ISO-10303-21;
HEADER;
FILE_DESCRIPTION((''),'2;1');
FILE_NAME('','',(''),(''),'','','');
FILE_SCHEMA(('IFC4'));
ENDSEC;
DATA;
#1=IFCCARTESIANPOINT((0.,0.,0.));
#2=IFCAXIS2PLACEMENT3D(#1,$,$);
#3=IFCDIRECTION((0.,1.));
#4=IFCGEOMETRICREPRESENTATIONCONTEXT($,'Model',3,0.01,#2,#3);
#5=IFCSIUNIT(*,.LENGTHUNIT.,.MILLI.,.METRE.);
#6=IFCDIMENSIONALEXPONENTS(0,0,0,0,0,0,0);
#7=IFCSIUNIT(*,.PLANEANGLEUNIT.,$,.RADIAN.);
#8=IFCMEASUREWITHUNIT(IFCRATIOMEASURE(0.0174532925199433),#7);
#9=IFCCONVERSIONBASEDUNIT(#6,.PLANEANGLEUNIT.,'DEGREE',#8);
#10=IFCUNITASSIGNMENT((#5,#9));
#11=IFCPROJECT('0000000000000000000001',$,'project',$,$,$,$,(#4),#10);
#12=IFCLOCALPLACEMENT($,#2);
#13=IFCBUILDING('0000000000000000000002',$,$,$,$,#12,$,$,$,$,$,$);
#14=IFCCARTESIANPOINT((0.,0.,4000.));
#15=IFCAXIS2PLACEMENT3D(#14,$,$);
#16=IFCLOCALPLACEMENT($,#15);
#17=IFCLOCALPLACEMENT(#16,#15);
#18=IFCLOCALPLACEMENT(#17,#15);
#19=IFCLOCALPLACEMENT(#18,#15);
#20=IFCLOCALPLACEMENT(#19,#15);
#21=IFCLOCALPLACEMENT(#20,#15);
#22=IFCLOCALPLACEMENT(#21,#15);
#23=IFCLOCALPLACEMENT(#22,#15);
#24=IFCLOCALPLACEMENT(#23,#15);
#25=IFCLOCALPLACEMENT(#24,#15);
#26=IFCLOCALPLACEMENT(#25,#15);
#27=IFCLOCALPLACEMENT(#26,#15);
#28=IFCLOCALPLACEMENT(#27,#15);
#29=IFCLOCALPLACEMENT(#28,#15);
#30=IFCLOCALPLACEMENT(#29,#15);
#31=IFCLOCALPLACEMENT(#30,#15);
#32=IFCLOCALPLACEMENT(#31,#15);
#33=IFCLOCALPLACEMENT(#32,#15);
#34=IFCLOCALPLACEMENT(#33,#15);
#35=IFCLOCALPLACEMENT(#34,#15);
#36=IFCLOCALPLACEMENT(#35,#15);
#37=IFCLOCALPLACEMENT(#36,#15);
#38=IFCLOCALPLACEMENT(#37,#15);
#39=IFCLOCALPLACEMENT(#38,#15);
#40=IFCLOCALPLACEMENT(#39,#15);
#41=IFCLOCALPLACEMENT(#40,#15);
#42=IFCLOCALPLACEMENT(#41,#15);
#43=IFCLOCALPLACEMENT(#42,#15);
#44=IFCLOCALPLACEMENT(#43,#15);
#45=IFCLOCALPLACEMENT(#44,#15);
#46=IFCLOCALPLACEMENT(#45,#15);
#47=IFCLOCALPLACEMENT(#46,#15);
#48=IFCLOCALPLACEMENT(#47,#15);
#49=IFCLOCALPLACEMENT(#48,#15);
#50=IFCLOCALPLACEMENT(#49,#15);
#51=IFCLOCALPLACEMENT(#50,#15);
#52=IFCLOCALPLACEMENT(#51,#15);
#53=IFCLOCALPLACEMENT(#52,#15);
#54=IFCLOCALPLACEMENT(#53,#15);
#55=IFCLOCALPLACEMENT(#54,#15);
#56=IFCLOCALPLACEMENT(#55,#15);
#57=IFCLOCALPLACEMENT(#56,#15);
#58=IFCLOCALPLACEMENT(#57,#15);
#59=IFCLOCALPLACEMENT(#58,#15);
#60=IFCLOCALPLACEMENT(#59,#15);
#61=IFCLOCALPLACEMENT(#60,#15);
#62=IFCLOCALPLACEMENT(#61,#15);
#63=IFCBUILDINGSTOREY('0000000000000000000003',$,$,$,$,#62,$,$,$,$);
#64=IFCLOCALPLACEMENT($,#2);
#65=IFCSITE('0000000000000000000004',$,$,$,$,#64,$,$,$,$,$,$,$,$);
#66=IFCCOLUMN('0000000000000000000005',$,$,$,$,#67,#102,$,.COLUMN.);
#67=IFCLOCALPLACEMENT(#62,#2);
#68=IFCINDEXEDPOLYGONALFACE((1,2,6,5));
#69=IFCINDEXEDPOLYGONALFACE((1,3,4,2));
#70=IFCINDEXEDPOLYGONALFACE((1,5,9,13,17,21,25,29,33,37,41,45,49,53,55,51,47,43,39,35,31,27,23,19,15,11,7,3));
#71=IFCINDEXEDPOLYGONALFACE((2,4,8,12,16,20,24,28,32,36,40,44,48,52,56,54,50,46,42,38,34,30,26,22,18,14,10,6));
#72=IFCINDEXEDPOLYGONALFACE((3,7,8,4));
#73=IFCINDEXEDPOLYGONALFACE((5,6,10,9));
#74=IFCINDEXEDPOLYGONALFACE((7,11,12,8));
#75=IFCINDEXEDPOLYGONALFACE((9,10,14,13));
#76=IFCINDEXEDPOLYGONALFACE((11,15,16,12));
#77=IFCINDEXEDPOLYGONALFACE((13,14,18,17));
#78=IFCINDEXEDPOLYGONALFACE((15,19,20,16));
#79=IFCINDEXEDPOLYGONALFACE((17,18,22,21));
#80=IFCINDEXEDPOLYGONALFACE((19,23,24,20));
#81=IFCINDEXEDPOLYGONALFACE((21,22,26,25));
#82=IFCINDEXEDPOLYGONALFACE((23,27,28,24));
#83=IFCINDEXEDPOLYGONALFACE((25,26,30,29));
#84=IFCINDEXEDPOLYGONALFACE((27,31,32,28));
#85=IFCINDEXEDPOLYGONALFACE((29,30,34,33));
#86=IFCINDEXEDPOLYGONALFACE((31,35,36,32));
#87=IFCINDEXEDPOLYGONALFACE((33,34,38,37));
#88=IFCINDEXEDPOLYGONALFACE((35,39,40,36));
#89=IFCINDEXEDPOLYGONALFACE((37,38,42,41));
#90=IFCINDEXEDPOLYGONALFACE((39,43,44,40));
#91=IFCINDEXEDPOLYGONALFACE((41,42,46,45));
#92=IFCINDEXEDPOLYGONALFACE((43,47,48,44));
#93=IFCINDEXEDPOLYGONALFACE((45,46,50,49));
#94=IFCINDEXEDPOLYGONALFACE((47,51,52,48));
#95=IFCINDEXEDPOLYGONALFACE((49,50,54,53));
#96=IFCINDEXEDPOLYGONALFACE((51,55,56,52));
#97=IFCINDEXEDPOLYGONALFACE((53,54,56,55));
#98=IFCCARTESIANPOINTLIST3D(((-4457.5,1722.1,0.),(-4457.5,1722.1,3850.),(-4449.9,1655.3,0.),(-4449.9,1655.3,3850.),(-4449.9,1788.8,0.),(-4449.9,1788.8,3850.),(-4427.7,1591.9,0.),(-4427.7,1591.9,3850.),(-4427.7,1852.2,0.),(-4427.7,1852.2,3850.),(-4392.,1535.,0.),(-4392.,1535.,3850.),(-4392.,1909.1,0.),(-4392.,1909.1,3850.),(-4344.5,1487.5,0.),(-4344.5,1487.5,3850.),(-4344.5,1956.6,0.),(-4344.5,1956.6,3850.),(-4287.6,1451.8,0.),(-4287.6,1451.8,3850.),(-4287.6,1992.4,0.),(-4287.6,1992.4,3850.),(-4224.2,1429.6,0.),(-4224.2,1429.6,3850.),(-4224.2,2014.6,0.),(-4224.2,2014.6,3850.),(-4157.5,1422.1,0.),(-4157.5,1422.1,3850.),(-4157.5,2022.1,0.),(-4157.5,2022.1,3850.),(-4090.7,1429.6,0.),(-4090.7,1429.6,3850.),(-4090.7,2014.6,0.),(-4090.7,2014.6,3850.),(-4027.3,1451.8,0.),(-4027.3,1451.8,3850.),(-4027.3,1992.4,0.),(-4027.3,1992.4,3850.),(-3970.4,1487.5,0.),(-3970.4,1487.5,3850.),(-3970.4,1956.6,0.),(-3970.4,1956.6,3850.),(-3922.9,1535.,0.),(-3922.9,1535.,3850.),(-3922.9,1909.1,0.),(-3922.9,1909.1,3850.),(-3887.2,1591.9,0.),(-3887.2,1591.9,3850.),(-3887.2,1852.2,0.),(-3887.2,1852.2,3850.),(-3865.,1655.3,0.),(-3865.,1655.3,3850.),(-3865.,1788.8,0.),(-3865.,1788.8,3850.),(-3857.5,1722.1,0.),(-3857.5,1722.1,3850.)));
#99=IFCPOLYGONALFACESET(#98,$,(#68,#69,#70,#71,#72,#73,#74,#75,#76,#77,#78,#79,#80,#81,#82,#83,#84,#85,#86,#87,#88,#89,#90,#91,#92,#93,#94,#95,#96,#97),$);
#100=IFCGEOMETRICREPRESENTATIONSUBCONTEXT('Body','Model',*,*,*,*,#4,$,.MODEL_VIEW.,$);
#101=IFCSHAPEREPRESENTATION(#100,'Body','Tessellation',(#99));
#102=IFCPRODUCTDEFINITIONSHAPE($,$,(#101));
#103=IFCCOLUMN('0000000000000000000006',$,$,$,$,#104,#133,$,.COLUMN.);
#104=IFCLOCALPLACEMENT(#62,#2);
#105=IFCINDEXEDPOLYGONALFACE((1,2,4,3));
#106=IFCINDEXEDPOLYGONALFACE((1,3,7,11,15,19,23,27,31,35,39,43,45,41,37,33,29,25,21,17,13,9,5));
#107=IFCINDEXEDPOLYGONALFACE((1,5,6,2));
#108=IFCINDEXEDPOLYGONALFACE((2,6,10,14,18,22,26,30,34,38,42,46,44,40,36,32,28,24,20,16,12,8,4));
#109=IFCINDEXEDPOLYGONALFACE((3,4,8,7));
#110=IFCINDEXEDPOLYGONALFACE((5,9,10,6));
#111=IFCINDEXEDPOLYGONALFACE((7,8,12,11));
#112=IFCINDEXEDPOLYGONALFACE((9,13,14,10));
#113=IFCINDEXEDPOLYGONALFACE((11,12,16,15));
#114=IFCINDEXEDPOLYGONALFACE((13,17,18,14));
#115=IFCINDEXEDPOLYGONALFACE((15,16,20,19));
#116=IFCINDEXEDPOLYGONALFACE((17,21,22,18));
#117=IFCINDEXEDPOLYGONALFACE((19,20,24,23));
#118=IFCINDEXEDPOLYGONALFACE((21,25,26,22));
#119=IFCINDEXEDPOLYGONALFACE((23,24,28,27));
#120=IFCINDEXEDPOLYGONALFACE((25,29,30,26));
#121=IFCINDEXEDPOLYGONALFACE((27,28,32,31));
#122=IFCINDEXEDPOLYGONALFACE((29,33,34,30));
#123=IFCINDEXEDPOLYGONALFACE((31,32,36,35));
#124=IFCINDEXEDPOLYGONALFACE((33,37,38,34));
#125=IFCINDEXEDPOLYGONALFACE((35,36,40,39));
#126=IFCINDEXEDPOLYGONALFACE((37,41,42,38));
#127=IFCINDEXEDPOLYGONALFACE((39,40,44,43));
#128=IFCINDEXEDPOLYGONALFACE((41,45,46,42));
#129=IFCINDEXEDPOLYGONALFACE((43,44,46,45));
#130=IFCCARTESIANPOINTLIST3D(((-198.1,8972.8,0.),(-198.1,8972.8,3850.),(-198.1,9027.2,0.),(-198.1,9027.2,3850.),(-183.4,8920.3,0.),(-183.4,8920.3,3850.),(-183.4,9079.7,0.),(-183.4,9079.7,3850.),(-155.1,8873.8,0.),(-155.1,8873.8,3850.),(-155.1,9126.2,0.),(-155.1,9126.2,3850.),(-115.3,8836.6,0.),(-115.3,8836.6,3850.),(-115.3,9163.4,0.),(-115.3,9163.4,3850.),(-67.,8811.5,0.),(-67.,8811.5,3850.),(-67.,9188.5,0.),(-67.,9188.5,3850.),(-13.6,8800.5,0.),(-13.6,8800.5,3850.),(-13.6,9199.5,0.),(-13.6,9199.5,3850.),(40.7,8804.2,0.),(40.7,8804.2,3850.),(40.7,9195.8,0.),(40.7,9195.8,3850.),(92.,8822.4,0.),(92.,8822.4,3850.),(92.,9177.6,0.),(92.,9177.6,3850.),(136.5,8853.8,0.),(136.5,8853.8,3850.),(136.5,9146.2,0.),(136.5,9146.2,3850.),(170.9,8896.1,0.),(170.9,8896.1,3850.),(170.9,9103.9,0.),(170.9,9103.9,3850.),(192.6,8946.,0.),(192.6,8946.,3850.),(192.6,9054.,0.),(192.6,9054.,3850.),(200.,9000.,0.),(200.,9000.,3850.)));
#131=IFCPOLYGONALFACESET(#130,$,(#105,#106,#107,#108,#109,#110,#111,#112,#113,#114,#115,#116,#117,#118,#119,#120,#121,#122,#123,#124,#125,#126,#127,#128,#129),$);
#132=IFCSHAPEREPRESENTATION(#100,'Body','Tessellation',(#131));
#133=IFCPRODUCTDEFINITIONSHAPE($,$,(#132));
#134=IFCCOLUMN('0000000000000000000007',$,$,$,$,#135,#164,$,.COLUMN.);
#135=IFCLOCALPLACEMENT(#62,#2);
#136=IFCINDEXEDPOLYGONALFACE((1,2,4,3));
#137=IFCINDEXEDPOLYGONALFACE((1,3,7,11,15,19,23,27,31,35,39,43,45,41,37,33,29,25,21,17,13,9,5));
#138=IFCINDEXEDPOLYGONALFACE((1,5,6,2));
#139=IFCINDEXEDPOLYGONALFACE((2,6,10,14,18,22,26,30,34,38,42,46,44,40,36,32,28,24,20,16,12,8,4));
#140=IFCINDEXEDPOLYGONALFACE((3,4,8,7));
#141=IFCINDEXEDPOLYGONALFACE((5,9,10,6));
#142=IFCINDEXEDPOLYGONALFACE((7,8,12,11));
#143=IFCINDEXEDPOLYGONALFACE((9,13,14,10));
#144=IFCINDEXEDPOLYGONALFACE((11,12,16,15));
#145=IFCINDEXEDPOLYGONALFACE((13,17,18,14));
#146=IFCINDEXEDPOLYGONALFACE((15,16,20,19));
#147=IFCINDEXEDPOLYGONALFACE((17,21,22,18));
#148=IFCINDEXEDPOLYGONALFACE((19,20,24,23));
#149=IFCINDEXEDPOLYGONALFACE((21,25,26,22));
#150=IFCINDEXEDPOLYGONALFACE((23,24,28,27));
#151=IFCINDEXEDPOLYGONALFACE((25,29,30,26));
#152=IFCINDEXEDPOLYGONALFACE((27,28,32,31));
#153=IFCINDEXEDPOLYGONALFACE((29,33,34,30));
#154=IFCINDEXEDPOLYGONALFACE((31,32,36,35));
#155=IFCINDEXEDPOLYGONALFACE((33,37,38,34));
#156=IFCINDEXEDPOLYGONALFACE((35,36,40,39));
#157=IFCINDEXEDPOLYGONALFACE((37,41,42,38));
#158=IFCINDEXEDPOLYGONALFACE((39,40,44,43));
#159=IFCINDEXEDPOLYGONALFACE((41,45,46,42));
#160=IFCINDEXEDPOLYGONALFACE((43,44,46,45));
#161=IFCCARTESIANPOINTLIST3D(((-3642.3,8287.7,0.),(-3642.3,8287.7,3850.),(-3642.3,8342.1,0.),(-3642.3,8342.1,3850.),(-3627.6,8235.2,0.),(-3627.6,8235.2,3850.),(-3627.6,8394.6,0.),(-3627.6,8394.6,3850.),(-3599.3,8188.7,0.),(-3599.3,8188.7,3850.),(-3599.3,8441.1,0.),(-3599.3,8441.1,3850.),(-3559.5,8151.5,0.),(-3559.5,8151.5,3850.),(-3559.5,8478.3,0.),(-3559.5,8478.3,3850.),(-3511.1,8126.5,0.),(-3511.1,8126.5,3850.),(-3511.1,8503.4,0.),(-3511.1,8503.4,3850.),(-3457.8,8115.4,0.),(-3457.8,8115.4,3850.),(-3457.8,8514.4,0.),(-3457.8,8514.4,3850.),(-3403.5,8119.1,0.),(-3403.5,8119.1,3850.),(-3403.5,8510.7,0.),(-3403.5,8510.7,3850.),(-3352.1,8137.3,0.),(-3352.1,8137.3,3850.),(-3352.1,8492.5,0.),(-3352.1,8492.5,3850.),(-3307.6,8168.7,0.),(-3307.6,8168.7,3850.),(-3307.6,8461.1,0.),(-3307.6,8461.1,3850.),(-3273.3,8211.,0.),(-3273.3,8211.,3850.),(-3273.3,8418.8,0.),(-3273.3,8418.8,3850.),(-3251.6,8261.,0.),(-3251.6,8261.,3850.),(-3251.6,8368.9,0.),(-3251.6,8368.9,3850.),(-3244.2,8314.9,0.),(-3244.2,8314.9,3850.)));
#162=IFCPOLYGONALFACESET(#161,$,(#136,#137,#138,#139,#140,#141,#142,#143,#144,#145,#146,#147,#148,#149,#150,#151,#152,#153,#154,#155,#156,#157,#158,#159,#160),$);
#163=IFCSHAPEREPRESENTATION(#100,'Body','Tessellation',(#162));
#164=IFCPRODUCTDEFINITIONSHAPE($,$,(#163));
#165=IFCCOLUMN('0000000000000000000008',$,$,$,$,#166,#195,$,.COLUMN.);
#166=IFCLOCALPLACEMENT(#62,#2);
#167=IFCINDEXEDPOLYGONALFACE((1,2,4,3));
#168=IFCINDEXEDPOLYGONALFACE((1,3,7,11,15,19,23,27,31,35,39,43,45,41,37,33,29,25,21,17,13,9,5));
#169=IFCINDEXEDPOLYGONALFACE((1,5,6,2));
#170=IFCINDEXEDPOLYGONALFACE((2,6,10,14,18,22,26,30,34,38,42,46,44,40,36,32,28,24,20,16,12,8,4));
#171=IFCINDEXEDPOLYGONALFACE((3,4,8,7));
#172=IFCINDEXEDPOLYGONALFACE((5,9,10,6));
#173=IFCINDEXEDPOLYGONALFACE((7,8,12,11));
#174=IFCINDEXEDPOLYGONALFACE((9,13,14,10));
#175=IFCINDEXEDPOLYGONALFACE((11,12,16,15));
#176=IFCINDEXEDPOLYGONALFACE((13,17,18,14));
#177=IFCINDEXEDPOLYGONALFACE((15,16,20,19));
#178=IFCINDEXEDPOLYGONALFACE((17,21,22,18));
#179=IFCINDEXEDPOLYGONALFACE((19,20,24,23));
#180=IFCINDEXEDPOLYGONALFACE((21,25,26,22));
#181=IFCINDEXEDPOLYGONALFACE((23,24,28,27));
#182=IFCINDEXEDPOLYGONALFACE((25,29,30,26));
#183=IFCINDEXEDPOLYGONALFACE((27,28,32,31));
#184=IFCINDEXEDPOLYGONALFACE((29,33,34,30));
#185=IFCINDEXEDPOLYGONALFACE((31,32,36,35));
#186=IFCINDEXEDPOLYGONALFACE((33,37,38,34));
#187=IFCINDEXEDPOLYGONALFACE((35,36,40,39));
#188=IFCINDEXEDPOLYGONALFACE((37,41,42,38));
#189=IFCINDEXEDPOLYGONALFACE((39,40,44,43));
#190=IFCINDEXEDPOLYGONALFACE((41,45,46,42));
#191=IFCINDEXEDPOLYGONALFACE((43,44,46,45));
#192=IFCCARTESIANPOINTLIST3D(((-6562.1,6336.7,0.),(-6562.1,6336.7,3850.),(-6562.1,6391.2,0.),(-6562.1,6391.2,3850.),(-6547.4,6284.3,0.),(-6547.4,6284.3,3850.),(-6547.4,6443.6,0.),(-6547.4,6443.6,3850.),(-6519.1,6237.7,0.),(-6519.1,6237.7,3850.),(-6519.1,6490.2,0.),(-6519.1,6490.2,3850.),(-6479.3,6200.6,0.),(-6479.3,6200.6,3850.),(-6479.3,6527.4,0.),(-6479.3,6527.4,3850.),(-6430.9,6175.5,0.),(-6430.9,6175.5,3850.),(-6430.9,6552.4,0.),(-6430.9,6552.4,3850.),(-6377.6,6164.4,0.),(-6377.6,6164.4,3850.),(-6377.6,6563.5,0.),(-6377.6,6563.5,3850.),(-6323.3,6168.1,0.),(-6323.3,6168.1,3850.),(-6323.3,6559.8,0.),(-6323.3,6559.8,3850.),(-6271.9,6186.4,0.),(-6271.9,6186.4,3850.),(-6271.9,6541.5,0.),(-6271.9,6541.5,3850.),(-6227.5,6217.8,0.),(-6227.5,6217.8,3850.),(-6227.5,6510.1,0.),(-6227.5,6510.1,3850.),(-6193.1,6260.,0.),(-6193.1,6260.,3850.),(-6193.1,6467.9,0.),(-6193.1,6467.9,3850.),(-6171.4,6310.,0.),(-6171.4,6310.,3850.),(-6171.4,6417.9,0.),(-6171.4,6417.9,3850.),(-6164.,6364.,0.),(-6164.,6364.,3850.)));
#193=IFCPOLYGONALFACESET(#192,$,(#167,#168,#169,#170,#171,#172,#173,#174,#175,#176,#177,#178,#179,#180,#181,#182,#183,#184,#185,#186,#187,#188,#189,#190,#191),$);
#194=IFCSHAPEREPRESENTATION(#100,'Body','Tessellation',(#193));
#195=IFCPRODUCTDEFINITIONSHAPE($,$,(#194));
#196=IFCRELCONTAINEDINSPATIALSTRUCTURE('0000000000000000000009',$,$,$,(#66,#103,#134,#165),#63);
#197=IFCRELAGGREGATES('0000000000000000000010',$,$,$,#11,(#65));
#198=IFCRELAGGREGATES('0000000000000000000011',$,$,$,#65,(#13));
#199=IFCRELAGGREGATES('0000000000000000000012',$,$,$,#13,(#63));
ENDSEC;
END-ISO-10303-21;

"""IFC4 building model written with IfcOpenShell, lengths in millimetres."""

from ifc_helpers import new_model, entity, si_unit, converted_unit, direction, frame, origin, origin_2d, place, context, subcontext, project, spatial, circle, extrude, element, save


model = new_model("IFC4")

# Units and contexts
model_context = context("Model", 3, precision=0.01, world=origin(), true_north=direction((0.0, 1.0)))
body_context = subcontext(model_context, "Body", "Model", "MODEL_VIEW")
ifc_project = project(units=[si_unit("LENGTHUNIT", "METRE", prefix="MILLI"), converted_unit("PLANEANGLEUNIT", "DEGREE", entity("IfcRatioMeasure", 0.0174532925199433), si_unit("PLANEANGLEUNIT", "RADIAN"), dimensions=[0, 0, 0, 0, 0, 0, 0])], contexts=[model_context])

# Site, building, storey
site_placement = place(None, origin())
site = spatial("IfcSite", under=ifc_project, at=site_placement)
building_placement = place(None, origin())
building = spatial("IfcBuilding", under=site, at=building_placement)
placement_1 = place(None, frame((0.0, 0.0, 4000.0)))
placement_2 = place(placement_1, frame((0.0, 0.0, 4000.0)))
placement_3 = place(placement_2, frame((0.0, 0.0, 4000.0)))
placement_4 = place(placement_3, frame((0.0, 0.0, 4000.0)))
placement_5 = place(placement_4, frame((0.0, 0.0, 4000.0)))
placement_6 = place(placement_5, frame((0.0, 0.0, 4000.0)))
placement_7 = place(placement_6, frame((0.0, 0.0, 4000.0)))
placement_8 = place(placement_7, frame((0.0, 0.0, 4000.0)))
placement_9 = place(placement_8, frame((0.0, 0.0, 4000.0)))
placement_10 = place(placement_9, frame((0.0, 0.0, 4000.0)))
placement_11 = place(placement_10, frame((0.0, 0.0, 4000.0)))
placement_12 = place(placement_11, frame((0.0, 0.0, 4000.0)))
placement_13 = place(placement_12, frame((0.0, 0.0, 4000.0)))
placement_14 = place(placement_13, frame((0.0, 0.0, 4000.0)))
placement_15 = place(placement_14, frame((0.0, 0.0, 4000.0)))
placement_16 = place(placement_15, frame((0.0, 0.0, 4000.0)))
placement_17 = place(placement_16, frame((0.0, 0.0, 4000.0)))
placement_18 = place(placement_17, frame((0.0, 0.0, 4000.0)))
placement_19 = place(placement_18, frame((0.0, 0.0, 4000.0)))
placement_20 = place(placement_19, frame((0.0, 0.0, 4000.0)))
placement_21 = place(placement_20, frame((0.0, 0.0, 4000.0)))
placement_22 = place(placement_21, frame((0.0, 0.0, 4000.0)))
placement_23 = place(placement_22, frame((0.0, 0.0, 4000.0)))
placement_24 = place(placement_23, frame((0.0, 0.0, 4000.0)))
placement_25 = place(placement_24, frame((0.0, 0.0, 4000.0)))
placement_26 = place(placement_25, frame((0.0, 0.0, 4000.0)))
placement_27 = place(placement_26, frame((0.0, 0.0, 4000.0)))
placement_28 = place(placement_27, frame((0.0, 0.0, 4000.0)))
placement_29 = place(placement_28, frame((0.0, 0.0, 4000.0)))
placement_30 = place(placement_29, frame((0.0, 0.0, 4000.0)))
placement_31 = place(placement_30, frame((0.0, 0.0, 4000.0)))
placement_32 = place(placement_31, frame((0.0, 0.0, 4000.0)))
placement_33 = place(placement_32, frame((0.0, 0.0, 4000.0)))
placement_34 = place(placement_33, frame((0.0, 0.0, 4000.0)))
placement_35 = place(placement_34, frame((0.0, 0.0, 4000.0)))
placement_36 = place(placement_35, frame((0.0, 0.0, 4000.0)))
placement_37 = place(placement_36, frame((0.0, 0.0, 4000.0)))
placement_38 = place(placement_37, frame((0.0, 0.0, 4000.0)))
placement_39 = place(placement_38, frame((0.0, 0.0, 4000.0)))
placement_40 = place(placement_39, frame((0.0, 0.0, 4000.0)))
placement_41 = place(placement_40, frame((0.0, 0.0, 4000.0)))
placement_42 = place(placement_41, frame((0.0, 0.0, 4000.0)))
placement_43 = place(placement_42, frame((0.0, 0.0, 4000.0)))
placement_44 = place(placement_43, frame((0.0, 0.0, 4000.0)))
placement_45 = place(placement_44, frame((0.0, 0.0, 4000.0)))
placement_46 = place(placement_45, frame((0.0, 0.0, 4000.0)))
storey_placement = place(placement_46, frame((0.0, 0.0, 4000.0)))
storey = spatial("IfcBuildingStorey", under=building, at=storey_placement)

# Columns
for number, where in (
    (1, (-4157.5, 1722.1, 0.0)),
):
    element("IfcColumn", number, at=place(storey_placement, frame(where)), inside=storey, PredefinedType="COLUMN", context=body_context, shape_type="SweptSolid", body=[
        extrude(circle(Radius=300.0, at=origin_2d()), origin(), (0.0, 0.0, 1.0), 3850.0),
    ])
for number, where in (
    (2, (0.0, 9000.0, 0.0)),
    (3, (-3444.2, 8314.9, 0.0)),
    (4, (-6364.0, 6364.0, 0.0)),
):
    element("IfcColumn", number, at=place(storey_placement, frame(where)), inside=storey, PredefinedType="COLUMN", context=body_context, shape_type="SweptSolid", body=[
        extrude(circle(Radius=200.0, at=origin_2d()), origin(), (0.0, 0.0, 1.0), 3850.0),
    ])

save(model, "model.ifc")
